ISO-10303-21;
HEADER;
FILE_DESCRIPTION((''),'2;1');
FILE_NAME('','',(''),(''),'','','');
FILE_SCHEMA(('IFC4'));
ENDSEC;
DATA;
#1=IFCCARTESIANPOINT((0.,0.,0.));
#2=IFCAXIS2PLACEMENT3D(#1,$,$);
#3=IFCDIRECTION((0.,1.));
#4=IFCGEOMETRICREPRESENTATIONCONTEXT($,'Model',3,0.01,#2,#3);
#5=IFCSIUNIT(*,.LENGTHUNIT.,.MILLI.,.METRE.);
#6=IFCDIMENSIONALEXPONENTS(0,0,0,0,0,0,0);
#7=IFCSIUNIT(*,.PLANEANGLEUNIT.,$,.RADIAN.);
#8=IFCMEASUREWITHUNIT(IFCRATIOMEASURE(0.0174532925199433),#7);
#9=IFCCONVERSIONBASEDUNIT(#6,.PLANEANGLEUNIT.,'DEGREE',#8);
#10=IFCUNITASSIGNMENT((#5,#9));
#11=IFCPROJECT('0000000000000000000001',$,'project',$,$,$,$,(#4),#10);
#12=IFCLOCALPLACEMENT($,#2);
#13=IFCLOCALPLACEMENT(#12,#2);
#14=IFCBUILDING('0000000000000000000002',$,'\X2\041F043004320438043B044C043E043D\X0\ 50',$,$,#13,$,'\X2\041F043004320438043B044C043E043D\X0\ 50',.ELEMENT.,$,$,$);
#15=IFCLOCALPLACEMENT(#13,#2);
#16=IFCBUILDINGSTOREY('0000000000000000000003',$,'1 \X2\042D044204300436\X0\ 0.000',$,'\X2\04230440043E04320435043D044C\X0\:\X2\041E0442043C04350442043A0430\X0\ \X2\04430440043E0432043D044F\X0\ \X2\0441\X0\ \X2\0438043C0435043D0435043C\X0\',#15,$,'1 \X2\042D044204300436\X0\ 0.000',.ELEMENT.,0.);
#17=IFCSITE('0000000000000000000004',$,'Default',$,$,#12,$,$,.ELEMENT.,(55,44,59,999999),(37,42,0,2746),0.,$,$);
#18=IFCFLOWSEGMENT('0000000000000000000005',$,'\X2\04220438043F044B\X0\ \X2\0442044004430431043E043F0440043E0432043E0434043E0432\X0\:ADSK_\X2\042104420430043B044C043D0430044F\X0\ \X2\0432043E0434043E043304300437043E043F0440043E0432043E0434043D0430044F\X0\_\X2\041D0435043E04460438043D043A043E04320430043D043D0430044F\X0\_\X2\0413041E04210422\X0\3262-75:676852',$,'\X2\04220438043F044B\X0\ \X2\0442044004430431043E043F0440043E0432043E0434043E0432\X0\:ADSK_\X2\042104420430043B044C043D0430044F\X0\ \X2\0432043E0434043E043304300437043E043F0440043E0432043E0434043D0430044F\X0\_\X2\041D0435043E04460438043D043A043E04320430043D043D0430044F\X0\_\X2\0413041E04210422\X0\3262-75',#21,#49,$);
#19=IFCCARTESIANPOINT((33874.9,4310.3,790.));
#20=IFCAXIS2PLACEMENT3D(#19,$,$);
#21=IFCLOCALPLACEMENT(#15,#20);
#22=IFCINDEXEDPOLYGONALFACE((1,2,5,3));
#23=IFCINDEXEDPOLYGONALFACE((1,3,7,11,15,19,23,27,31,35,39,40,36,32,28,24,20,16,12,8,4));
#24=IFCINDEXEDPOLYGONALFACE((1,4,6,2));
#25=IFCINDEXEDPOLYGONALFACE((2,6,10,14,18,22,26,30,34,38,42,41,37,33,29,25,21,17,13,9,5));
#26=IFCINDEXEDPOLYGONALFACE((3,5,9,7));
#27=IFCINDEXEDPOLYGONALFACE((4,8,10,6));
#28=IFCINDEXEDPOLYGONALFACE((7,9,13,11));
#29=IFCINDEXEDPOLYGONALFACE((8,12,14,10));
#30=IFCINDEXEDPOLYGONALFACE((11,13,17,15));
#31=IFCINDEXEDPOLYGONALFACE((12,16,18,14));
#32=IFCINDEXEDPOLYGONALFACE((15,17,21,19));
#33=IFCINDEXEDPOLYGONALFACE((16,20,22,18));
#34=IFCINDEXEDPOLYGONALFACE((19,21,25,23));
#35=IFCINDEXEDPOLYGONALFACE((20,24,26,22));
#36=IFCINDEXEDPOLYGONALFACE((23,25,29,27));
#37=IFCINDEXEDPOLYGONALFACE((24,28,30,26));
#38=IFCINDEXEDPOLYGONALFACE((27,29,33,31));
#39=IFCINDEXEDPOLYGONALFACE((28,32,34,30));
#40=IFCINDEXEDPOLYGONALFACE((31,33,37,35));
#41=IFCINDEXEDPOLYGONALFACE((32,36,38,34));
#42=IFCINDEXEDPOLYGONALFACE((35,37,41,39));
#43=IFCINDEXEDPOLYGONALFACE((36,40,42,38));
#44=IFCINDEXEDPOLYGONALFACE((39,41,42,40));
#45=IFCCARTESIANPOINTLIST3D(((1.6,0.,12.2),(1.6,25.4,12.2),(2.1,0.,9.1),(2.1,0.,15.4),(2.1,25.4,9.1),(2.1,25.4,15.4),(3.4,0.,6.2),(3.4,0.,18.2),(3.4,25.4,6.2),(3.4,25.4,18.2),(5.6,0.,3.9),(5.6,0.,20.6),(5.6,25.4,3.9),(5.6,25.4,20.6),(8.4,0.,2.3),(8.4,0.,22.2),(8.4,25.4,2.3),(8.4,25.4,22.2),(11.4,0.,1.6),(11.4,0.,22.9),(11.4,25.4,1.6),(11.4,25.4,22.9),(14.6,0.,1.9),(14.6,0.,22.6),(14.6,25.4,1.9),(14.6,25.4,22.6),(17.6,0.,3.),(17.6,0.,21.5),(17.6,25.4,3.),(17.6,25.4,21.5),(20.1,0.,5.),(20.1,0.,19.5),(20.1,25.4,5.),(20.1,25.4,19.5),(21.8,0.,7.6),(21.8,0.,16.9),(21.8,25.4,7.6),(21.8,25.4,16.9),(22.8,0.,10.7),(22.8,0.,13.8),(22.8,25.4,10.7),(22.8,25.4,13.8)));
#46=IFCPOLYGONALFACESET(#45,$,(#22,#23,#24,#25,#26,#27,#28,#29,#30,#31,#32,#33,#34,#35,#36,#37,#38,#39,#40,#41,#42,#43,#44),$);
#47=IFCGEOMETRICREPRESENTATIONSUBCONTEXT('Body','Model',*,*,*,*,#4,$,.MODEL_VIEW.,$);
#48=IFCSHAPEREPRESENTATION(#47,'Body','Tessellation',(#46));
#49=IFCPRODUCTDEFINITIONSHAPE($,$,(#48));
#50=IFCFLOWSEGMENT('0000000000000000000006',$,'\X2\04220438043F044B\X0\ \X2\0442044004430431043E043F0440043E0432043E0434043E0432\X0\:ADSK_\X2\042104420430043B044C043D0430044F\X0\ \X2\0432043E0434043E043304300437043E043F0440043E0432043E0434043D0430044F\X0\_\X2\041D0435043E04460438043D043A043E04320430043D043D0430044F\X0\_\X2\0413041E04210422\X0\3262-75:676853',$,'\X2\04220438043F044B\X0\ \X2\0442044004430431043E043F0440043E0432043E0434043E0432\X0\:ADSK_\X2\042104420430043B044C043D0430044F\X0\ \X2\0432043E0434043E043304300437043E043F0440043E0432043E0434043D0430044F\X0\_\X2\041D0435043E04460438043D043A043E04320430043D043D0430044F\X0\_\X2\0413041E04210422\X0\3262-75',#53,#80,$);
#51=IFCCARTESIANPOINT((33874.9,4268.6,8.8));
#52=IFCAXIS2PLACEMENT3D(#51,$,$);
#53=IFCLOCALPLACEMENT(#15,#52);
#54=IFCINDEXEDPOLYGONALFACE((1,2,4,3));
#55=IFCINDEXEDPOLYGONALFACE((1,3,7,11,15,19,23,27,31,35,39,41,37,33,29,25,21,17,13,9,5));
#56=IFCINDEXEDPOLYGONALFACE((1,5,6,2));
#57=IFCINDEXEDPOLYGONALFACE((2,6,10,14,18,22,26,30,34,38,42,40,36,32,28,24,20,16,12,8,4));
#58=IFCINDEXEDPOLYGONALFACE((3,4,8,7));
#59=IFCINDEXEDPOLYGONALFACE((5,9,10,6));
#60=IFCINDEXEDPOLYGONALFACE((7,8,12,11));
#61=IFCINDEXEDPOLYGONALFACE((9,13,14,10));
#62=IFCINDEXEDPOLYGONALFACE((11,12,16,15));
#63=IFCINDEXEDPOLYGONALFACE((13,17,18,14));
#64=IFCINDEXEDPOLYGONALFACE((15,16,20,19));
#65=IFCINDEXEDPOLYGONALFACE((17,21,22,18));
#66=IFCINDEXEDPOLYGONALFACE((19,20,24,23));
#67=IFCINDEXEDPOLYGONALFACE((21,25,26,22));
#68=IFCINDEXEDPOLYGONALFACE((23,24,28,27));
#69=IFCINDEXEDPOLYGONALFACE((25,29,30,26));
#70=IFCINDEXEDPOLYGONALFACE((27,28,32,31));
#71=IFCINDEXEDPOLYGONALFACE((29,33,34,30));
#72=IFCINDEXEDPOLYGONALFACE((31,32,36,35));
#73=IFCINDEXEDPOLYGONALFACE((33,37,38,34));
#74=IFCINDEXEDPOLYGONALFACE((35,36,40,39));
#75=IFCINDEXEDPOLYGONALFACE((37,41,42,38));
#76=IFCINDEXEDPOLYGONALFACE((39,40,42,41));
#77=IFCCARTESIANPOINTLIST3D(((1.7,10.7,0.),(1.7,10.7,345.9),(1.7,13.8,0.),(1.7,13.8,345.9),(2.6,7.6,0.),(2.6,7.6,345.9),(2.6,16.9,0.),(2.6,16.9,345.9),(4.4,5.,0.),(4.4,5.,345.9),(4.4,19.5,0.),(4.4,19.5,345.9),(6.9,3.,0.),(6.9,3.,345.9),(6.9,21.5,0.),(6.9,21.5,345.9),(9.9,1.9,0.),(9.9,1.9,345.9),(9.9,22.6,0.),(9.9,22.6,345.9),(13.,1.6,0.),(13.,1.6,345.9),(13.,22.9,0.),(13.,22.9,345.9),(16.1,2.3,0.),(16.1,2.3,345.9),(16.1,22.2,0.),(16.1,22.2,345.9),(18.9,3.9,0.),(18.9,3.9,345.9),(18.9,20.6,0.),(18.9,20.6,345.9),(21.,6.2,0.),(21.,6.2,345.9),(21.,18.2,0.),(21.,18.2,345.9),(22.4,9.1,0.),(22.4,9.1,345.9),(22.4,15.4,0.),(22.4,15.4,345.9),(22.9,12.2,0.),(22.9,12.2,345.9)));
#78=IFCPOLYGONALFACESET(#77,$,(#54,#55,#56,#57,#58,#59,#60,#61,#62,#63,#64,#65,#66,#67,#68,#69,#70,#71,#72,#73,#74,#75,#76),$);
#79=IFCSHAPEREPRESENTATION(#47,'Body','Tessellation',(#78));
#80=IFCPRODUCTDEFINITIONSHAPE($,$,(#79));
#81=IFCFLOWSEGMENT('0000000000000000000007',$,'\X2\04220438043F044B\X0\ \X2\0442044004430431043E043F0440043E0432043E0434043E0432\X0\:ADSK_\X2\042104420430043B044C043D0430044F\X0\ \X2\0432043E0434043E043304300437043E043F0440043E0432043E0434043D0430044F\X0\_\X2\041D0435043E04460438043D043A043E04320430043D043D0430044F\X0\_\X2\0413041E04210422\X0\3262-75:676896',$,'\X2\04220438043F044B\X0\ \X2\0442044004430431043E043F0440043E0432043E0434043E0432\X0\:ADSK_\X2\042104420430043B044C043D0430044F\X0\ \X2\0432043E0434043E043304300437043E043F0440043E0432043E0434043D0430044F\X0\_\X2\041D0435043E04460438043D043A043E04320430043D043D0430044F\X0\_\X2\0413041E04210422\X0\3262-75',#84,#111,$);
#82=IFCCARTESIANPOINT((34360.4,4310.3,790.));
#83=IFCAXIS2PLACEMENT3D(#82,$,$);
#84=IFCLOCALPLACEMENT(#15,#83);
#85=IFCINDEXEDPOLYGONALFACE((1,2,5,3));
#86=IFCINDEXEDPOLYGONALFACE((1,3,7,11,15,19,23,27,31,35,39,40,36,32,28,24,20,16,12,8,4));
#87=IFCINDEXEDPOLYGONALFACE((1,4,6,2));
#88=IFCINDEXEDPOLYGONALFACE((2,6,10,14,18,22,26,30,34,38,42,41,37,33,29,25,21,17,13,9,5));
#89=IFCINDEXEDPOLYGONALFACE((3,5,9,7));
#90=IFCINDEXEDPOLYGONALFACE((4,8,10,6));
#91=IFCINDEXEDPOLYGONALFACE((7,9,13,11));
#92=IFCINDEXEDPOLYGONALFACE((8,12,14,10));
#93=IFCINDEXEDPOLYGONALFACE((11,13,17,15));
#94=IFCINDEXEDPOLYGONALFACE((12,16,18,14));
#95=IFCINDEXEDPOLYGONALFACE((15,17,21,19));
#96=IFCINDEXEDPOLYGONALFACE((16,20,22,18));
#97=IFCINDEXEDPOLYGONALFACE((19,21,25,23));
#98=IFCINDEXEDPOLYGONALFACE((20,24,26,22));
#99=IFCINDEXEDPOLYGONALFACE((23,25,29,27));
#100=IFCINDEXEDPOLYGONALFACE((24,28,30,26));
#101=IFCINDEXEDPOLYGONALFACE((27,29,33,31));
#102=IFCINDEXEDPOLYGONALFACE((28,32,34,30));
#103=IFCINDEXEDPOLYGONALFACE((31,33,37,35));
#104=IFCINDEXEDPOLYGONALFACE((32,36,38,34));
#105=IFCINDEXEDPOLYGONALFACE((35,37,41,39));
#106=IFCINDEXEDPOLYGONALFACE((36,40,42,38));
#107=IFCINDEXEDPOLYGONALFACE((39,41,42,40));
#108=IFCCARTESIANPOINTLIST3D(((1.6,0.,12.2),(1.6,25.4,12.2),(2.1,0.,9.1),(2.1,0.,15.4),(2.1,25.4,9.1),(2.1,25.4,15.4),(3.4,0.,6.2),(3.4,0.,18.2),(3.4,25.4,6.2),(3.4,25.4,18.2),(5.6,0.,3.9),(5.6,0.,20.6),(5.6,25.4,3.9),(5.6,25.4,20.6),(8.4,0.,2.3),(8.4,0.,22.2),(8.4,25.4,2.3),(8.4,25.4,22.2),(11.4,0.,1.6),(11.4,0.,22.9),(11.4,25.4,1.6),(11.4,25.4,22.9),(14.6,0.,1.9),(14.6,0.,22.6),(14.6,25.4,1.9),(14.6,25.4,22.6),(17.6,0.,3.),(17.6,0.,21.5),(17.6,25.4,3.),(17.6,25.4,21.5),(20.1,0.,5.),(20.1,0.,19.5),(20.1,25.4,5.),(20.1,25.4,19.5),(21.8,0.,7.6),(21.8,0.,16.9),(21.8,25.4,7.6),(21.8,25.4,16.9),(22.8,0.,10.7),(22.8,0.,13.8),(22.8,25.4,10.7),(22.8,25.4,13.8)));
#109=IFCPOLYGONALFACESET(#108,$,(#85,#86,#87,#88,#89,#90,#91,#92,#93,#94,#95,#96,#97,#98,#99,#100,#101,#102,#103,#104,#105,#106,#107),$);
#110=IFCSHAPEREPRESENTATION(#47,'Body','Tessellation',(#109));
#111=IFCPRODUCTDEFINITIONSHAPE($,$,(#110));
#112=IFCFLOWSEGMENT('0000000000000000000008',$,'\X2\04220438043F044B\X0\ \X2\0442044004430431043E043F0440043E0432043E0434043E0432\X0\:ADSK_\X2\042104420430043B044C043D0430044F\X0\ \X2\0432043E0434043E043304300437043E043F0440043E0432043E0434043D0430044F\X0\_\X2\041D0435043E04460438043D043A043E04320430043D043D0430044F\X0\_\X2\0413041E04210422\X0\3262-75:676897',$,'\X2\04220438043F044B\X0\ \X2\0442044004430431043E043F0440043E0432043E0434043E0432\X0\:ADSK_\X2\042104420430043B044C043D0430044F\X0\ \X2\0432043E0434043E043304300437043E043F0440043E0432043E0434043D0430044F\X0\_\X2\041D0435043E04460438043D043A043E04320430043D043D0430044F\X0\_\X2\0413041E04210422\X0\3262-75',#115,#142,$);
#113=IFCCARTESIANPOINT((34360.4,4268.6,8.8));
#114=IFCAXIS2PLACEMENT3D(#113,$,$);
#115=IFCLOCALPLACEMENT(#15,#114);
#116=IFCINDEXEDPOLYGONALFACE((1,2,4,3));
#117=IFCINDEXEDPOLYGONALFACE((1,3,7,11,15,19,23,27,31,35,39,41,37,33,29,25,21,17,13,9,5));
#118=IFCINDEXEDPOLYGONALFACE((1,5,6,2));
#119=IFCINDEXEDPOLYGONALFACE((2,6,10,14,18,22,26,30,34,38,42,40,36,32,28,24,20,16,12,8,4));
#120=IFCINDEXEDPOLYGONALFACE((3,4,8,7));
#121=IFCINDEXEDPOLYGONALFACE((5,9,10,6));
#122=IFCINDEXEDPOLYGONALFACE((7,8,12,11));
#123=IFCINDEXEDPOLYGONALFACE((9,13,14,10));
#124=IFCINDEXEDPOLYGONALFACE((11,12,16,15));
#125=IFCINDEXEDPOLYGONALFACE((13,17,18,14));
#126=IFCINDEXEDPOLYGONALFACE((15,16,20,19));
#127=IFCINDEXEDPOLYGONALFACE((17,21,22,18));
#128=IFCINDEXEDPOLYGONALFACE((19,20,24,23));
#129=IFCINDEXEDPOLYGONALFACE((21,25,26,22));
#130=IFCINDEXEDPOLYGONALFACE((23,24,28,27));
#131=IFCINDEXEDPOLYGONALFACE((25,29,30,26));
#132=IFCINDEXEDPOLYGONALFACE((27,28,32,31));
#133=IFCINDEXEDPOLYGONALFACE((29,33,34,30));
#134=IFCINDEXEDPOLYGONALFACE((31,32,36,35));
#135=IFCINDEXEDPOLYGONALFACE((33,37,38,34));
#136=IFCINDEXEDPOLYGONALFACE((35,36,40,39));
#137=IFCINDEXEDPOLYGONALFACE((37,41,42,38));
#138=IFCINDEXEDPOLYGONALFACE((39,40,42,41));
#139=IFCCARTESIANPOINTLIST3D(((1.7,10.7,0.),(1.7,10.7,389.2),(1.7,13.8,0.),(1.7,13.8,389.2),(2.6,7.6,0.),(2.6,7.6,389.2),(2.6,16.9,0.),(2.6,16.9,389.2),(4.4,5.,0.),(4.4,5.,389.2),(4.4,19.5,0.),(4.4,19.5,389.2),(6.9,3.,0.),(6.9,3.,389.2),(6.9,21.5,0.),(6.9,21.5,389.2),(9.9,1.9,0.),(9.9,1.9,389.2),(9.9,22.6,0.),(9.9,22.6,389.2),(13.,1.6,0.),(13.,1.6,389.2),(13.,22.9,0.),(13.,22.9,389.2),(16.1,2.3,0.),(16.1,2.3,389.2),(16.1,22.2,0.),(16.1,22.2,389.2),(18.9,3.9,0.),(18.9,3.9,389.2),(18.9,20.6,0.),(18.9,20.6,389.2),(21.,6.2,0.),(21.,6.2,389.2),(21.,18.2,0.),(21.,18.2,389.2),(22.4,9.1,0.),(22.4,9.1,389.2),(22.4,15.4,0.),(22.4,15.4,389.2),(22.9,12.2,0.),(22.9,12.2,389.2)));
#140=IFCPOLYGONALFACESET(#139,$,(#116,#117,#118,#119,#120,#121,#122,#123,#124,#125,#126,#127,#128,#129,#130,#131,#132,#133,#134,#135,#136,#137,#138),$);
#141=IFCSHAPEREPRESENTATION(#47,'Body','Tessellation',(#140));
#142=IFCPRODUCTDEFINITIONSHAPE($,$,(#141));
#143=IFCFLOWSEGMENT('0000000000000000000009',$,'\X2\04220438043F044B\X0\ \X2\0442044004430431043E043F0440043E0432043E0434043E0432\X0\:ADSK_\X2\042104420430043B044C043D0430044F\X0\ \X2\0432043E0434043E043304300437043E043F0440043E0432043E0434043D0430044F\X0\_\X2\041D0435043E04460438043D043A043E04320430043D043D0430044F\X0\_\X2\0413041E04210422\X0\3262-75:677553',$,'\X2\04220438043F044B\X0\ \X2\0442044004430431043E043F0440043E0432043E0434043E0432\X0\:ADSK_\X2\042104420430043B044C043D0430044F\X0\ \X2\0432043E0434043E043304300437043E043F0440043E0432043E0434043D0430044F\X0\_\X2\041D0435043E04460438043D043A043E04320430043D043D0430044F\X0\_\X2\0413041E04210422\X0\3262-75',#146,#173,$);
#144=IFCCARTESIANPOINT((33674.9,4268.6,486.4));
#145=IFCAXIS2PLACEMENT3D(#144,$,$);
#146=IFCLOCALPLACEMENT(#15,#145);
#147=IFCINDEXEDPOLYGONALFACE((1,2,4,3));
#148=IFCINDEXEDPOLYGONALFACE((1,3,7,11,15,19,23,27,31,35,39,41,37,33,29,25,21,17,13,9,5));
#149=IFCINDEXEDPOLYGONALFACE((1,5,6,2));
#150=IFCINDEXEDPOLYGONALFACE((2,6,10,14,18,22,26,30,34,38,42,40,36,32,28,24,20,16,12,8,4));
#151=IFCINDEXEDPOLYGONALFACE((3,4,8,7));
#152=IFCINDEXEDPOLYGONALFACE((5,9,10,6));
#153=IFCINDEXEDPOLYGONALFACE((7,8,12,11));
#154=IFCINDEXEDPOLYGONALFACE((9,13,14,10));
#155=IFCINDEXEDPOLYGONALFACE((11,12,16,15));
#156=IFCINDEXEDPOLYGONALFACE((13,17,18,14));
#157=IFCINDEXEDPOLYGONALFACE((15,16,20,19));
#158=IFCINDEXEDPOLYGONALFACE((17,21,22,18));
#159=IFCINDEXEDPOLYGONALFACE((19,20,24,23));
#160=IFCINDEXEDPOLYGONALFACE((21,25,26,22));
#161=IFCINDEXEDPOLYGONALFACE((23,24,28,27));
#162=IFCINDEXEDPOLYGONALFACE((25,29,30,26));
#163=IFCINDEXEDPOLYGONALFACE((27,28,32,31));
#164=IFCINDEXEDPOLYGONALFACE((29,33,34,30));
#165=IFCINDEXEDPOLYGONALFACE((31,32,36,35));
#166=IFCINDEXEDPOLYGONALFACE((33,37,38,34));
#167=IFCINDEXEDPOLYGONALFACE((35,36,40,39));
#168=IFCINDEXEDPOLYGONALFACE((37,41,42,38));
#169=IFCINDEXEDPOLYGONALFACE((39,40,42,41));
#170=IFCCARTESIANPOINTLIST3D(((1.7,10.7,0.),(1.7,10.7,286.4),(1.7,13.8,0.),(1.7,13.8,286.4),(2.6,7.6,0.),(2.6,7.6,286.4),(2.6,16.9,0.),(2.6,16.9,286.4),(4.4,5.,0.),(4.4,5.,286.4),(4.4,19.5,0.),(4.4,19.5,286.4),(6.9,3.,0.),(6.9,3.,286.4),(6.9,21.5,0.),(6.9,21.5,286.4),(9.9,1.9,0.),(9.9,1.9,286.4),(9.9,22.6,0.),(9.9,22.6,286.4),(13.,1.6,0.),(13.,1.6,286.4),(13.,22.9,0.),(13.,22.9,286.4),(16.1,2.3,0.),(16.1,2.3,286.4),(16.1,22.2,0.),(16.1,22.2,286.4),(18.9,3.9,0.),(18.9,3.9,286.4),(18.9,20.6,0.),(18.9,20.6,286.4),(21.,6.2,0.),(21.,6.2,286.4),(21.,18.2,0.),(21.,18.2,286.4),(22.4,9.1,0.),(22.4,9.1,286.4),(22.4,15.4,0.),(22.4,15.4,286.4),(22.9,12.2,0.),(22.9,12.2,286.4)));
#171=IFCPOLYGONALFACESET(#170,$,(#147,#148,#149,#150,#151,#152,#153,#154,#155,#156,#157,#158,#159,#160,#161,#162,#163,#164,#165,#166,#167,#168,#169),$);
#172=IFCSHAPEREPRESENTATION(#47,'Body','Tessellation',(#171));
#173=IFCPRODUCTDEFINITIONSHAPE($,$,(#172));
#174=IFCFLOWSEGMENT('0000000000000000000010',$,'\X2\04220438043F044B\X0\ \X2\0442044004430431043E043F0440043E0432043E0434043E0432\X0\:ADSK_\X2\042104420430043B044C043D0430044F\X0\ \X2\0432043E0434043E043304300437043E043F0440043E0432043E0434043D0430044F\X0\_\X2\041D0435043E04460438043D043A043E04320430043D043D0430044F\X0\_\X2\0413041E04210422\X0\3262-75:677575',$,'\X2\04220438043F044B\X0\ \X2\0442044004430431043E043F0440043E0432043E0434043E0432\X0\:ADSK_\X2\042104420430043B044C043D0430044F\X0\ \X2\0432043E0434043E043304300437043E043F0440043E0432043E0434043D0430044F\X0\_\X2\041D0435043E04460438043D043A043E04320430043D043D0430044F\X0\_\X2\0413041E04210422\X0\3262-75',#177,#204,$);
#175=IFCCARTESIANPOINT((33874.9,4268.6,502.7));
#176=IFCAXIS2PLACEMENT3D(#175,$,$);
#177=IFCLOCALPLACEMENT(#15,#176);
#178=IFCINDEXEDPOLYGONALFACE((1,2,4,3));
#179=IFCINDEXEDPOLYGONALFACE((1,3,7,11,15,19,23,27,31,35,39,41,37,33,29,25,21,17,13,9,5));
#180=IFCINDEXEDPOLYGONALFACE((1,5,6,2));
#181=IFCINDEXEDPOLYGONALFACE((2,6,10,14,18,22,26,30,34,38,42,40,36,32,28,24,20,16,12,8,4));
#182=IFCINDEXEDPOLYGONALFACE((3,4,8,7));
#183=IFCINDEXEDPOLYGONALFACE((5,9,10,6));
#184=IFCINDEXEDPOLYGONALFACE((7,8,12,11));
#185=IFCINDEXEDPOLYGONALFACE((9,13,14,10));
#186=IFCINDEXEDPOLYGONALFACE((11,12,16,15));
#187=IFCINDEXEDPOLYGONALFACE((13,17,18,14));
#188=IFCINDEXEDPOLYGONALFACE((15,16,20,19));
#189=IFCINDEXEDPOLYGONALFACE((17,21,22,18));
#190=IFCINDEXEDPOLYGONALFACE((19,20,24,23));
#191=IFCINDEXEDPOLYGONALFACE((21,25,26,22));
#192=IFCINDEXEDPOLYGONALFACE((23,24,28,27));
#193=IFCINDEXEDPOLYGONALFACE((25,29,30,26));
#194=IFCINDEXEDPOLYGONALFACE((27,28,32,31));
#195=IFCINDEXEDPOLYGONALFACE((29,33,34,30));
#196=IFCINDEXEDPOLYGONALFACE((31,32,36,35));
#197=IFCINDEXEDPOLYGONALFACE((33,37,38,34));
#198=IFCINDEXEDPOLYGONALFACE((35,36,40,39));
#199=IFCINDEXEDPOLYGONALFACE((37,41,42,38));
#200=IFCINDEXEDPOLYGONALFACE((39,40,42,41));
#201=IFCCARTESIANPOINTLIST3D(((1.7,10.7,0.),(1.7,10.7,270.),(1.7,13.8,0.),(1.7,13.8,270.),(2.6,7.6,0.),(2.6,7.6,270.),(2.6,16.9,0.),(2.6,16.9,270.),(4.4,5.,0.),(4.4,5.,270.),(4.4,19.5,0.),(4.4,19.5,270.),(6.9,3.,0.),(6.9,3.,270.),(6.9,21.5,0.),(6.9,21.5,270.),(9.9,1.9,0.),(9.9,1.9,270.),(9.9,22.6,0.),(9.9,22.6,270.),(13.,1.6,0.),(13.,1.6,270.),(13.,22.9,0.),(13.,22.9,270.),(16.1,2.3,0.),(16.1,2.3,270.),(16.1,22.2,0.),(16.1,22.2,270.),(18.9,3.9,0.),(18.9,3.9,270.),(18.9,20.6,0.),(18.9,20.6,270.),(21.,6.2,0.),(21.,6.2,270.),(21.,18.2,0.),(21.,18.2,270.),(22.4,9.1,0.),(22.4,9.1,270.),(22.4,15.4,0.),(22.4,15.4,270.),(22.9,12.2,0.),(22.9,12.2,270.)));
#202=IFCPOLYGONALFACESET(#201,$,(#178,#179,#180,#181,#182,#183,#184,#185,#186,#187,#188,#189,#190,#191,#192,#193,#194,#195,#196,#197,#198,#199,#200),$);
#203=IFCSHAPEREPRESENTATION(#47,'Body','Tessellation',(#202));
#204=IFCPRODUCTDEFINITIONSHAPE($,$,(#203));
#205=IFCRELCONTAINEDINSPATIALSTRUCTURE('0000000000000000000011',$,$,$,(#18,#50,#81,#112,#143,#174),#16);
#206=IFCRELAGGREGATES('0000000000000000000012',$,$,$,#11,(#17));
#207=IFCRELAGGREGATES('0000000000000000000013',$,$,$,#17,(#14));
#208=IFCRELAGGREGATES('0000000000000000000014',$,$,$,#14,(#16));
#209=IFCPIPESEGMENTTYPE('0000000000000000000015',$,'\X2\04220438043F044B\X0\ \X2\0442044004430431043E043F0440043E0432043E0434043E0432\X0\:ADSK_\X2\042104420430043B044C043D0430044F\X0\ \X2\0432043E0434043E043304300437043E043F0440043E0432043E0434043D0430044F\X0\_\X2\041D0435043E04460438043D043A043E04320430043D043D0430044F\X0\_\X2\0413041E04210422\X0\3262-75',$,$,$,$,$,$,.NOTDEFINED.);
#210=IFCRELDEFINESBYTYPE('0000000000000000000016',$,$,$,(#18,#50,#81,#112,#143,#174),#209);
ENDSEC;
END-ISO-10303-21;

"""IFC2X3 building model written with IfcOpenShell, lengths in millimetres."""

from ifc_helpers import new_model, entity, si_unit, converted_unit, direction, frame, origin, origin_2d_with_axis, place, context, subcontext, project, spatial, circle, extrude, type_object, element, save


model = new_model("IFC2X3")

# Units and contexts
model_context = context("Model", 3, precision=0.01, world=origin(), true_north=direction((0.0, 1.0)))
body_context = subcontext(model_context, "Body", "Model", "MODEL_VIEW")
ifc_project = project(units=[si_unit("LENGTHUNIT", "METRE", prefix="MILLI"), converted_unit("PLANEANGLEUNIT", "DEGREE", entity("IfcRatioMeasure", 0.0174532925199433), si_unit("PLANEANGLEUNIT", "RADIAN"), dimensions=[0, 0, 0, 0, 0, 0, 0])], contexts=[model_context])

# Site, building, storey
site_placement = place(None, origin())
site = spatial("IfcSite", under=ifc_project, at=site_placement, Name="Default", CompositionType="ELEMENT", RefLatitude=(55, 44, 59, 999999), RefLongitude=(37, 42, 0, 2746), RefElevation=0.0)
building_placement = place(site_placement, origin())
building = spatial("IfcBuilding", under=site, at=building_placement, Name="Павильон 50", LongName="Павильон 50", CompositionType="ELEMENT")
storey_placement = place(building_placement, origin())
storey = spatial("IfcBuildingStorey", under=building, at=storey_placement, Name="1 Этаж 0.000", ObjectType="Уровень:Отметка уровня с именем", LongName="1 Этаж 0.000", CompositionType="ELEMENT", Elevation=0.0)

# Flow segments
pipe_segment_type = type_object("IfcPipeSegmentType", Name="Типы трубопроводов:ADSK_Стальная водогазопроводная_Неоцинкованная_ГОСТ3262-75", PredefinedType="NOTDEFINED")
flow_segment_1_placement = place(storey_placement, frame((33874.9, 4310.3, 790.0)))
element("IfcFlowSegment", 1, at=flow_segment_1_placement, inside=storey, type_object=pipe_segment_type, Name="Типы трубопроводов:ADSK_Стальная водогазопроводная_Неоцинкованная_ГОСТ3262-75:676852", ObjectType="Типы трубопроводов:ADSK_Стальная водогазопроводная_Неоцинкованная_ГОСТ3262-75", context=body_context, shape_type="SweptSolid", body=[
    extrude(circle(Radius=10.7, at=origin_2d_with_axis()), frame((12.2, 0.0, 12.2), z_axis=(0.0, 1.0, 0.0), x_axis=(-1.0, 0.0, 0.0)), (0.0, 0.0, 1.0), 25.4),
])
flow_segment_2_placement = place(storey_placement, frame((33874.9, 4268.6, 8.8)))
element("IfcFlowSegment", 2, at=flow_segment_2_placement, inside=storey, type_object=pipe_segment_type, Name="Типы трубопроводов:ADSK_Стальная водогазопроводная_Неоцинкованная_ГОСТ3262-75:676853", ObjectType="Типы трубопроводов:ADSK_Стальная водогазопроводная_Неоцинкованная_ГОСТ3262-75", context=body_context, shape_type="SweptSolid", body=[
    extrude(circle(Radius=10.7, at=origin_2d_with_axis()), frame((12.2, 12.2, 0.0)), (0.0, 0.0, 1.0), 345.9),
])
flow_segment_3_placement = place(storey_placement, frame((34360.4, 4310.3, 790.0)))
element("IfcFlowSegment", 3, at=flow_segment_3_placement, inside=storey, type_object=pipe_segment_type, Name="Типы трубопроводов:ADSK_Стальная водогазопроводная_Неоцинкованная_ГОСТ3262-75:676896", ObjectType="Типы трубопроводов:ADSK_Стальная водогазопроводная_Неоцинкованная_ГОСТ3262-75", context=body_context, shape_type="SweptSolid", body=[
    extrude(circle(Radius=10.7, at=origin_2d_with_axis()), frame((12.2, 0.0, 12.2), z_axis=(0.0, 1.0, 0.0), x_axis=(-1.0, 0.0, 0.0)), (0.0, 0.0, 1.0), 25.4),
])
flow_segment_4_placement = place(storey_placement, frame((34360.4, 4268.6, 8.8)))
element("IfcFlowSegment", 4, at=flow_segment_4_placement, inside=storey, type_object=pipe_segment_type, Name="Типы трубопроводов:ADSK_Стальная водогазопроводная_Неоцинкованная_ГОСТ3262-75:676897", ObjectType="Типы трубопроводов:ADSK_Стальная водогазопроводная_Неоцинкованная_ГОСТ3262-75", context=body_context, shape_type="SweptSolid", body=[
    extrude(circle(Radius=10.7, at=origin_2d_with_axis()), frame((12.2, 12.2, 0.0)), (0.0, 0.0, 1.0), 389.2),
])
flow_segment_5_placement = place(storey_placement, frame((33674.9, 4268.6, 486.4)))
element("IfcFlowSegment", 5, at=flow_segment_5_placement, inside=storey, type_object=pipe_segment_type, Name="Типы трубопроводов:ADSK_Стальная водогазопроводная_Неоцинкованная_ГОСТ3262-75:677553", ObjectType="Типы трубопроводов:ADSK_Стальная водогазопроводная_Неоцинкованная_ГОСТ3262-75", context=body_context, shape_type="SweptSolid", body=[
    extrude(circle(Radius=10.7, at=origin_2d_with_axis()), frame((12.2, 12.2, 0.0)), (0.0, 0.0, 1.0), 286.4),
])
flow_segment_6_placement = place(storey_placement, frame((33874.9, 4268.6, 502.7)))
element("IfcFlowSegment", 6, at=flow_segment_6_placement, inside=storey, type_object=pipe_segment_type, Name="Типы трубопроводов:ADSK_Стальная водогазопроводная_Неоцинкованная_ГОСТ3262-75:677575", ObjectType="Типы трубопроводов:ADSK_Стальная водогазопроводная_Неоцинкованная_ГОСТ3262-75", context=body_context, shape_type="SweptSolid", body=[
    extrude(circle(Radius=10.7, at=origin_2d_with_axis()), frame((12.2, 12.2, 0.0)), (0.0, 0.0, 1.0), 270.0),
])

save(model, "model.ifc")
